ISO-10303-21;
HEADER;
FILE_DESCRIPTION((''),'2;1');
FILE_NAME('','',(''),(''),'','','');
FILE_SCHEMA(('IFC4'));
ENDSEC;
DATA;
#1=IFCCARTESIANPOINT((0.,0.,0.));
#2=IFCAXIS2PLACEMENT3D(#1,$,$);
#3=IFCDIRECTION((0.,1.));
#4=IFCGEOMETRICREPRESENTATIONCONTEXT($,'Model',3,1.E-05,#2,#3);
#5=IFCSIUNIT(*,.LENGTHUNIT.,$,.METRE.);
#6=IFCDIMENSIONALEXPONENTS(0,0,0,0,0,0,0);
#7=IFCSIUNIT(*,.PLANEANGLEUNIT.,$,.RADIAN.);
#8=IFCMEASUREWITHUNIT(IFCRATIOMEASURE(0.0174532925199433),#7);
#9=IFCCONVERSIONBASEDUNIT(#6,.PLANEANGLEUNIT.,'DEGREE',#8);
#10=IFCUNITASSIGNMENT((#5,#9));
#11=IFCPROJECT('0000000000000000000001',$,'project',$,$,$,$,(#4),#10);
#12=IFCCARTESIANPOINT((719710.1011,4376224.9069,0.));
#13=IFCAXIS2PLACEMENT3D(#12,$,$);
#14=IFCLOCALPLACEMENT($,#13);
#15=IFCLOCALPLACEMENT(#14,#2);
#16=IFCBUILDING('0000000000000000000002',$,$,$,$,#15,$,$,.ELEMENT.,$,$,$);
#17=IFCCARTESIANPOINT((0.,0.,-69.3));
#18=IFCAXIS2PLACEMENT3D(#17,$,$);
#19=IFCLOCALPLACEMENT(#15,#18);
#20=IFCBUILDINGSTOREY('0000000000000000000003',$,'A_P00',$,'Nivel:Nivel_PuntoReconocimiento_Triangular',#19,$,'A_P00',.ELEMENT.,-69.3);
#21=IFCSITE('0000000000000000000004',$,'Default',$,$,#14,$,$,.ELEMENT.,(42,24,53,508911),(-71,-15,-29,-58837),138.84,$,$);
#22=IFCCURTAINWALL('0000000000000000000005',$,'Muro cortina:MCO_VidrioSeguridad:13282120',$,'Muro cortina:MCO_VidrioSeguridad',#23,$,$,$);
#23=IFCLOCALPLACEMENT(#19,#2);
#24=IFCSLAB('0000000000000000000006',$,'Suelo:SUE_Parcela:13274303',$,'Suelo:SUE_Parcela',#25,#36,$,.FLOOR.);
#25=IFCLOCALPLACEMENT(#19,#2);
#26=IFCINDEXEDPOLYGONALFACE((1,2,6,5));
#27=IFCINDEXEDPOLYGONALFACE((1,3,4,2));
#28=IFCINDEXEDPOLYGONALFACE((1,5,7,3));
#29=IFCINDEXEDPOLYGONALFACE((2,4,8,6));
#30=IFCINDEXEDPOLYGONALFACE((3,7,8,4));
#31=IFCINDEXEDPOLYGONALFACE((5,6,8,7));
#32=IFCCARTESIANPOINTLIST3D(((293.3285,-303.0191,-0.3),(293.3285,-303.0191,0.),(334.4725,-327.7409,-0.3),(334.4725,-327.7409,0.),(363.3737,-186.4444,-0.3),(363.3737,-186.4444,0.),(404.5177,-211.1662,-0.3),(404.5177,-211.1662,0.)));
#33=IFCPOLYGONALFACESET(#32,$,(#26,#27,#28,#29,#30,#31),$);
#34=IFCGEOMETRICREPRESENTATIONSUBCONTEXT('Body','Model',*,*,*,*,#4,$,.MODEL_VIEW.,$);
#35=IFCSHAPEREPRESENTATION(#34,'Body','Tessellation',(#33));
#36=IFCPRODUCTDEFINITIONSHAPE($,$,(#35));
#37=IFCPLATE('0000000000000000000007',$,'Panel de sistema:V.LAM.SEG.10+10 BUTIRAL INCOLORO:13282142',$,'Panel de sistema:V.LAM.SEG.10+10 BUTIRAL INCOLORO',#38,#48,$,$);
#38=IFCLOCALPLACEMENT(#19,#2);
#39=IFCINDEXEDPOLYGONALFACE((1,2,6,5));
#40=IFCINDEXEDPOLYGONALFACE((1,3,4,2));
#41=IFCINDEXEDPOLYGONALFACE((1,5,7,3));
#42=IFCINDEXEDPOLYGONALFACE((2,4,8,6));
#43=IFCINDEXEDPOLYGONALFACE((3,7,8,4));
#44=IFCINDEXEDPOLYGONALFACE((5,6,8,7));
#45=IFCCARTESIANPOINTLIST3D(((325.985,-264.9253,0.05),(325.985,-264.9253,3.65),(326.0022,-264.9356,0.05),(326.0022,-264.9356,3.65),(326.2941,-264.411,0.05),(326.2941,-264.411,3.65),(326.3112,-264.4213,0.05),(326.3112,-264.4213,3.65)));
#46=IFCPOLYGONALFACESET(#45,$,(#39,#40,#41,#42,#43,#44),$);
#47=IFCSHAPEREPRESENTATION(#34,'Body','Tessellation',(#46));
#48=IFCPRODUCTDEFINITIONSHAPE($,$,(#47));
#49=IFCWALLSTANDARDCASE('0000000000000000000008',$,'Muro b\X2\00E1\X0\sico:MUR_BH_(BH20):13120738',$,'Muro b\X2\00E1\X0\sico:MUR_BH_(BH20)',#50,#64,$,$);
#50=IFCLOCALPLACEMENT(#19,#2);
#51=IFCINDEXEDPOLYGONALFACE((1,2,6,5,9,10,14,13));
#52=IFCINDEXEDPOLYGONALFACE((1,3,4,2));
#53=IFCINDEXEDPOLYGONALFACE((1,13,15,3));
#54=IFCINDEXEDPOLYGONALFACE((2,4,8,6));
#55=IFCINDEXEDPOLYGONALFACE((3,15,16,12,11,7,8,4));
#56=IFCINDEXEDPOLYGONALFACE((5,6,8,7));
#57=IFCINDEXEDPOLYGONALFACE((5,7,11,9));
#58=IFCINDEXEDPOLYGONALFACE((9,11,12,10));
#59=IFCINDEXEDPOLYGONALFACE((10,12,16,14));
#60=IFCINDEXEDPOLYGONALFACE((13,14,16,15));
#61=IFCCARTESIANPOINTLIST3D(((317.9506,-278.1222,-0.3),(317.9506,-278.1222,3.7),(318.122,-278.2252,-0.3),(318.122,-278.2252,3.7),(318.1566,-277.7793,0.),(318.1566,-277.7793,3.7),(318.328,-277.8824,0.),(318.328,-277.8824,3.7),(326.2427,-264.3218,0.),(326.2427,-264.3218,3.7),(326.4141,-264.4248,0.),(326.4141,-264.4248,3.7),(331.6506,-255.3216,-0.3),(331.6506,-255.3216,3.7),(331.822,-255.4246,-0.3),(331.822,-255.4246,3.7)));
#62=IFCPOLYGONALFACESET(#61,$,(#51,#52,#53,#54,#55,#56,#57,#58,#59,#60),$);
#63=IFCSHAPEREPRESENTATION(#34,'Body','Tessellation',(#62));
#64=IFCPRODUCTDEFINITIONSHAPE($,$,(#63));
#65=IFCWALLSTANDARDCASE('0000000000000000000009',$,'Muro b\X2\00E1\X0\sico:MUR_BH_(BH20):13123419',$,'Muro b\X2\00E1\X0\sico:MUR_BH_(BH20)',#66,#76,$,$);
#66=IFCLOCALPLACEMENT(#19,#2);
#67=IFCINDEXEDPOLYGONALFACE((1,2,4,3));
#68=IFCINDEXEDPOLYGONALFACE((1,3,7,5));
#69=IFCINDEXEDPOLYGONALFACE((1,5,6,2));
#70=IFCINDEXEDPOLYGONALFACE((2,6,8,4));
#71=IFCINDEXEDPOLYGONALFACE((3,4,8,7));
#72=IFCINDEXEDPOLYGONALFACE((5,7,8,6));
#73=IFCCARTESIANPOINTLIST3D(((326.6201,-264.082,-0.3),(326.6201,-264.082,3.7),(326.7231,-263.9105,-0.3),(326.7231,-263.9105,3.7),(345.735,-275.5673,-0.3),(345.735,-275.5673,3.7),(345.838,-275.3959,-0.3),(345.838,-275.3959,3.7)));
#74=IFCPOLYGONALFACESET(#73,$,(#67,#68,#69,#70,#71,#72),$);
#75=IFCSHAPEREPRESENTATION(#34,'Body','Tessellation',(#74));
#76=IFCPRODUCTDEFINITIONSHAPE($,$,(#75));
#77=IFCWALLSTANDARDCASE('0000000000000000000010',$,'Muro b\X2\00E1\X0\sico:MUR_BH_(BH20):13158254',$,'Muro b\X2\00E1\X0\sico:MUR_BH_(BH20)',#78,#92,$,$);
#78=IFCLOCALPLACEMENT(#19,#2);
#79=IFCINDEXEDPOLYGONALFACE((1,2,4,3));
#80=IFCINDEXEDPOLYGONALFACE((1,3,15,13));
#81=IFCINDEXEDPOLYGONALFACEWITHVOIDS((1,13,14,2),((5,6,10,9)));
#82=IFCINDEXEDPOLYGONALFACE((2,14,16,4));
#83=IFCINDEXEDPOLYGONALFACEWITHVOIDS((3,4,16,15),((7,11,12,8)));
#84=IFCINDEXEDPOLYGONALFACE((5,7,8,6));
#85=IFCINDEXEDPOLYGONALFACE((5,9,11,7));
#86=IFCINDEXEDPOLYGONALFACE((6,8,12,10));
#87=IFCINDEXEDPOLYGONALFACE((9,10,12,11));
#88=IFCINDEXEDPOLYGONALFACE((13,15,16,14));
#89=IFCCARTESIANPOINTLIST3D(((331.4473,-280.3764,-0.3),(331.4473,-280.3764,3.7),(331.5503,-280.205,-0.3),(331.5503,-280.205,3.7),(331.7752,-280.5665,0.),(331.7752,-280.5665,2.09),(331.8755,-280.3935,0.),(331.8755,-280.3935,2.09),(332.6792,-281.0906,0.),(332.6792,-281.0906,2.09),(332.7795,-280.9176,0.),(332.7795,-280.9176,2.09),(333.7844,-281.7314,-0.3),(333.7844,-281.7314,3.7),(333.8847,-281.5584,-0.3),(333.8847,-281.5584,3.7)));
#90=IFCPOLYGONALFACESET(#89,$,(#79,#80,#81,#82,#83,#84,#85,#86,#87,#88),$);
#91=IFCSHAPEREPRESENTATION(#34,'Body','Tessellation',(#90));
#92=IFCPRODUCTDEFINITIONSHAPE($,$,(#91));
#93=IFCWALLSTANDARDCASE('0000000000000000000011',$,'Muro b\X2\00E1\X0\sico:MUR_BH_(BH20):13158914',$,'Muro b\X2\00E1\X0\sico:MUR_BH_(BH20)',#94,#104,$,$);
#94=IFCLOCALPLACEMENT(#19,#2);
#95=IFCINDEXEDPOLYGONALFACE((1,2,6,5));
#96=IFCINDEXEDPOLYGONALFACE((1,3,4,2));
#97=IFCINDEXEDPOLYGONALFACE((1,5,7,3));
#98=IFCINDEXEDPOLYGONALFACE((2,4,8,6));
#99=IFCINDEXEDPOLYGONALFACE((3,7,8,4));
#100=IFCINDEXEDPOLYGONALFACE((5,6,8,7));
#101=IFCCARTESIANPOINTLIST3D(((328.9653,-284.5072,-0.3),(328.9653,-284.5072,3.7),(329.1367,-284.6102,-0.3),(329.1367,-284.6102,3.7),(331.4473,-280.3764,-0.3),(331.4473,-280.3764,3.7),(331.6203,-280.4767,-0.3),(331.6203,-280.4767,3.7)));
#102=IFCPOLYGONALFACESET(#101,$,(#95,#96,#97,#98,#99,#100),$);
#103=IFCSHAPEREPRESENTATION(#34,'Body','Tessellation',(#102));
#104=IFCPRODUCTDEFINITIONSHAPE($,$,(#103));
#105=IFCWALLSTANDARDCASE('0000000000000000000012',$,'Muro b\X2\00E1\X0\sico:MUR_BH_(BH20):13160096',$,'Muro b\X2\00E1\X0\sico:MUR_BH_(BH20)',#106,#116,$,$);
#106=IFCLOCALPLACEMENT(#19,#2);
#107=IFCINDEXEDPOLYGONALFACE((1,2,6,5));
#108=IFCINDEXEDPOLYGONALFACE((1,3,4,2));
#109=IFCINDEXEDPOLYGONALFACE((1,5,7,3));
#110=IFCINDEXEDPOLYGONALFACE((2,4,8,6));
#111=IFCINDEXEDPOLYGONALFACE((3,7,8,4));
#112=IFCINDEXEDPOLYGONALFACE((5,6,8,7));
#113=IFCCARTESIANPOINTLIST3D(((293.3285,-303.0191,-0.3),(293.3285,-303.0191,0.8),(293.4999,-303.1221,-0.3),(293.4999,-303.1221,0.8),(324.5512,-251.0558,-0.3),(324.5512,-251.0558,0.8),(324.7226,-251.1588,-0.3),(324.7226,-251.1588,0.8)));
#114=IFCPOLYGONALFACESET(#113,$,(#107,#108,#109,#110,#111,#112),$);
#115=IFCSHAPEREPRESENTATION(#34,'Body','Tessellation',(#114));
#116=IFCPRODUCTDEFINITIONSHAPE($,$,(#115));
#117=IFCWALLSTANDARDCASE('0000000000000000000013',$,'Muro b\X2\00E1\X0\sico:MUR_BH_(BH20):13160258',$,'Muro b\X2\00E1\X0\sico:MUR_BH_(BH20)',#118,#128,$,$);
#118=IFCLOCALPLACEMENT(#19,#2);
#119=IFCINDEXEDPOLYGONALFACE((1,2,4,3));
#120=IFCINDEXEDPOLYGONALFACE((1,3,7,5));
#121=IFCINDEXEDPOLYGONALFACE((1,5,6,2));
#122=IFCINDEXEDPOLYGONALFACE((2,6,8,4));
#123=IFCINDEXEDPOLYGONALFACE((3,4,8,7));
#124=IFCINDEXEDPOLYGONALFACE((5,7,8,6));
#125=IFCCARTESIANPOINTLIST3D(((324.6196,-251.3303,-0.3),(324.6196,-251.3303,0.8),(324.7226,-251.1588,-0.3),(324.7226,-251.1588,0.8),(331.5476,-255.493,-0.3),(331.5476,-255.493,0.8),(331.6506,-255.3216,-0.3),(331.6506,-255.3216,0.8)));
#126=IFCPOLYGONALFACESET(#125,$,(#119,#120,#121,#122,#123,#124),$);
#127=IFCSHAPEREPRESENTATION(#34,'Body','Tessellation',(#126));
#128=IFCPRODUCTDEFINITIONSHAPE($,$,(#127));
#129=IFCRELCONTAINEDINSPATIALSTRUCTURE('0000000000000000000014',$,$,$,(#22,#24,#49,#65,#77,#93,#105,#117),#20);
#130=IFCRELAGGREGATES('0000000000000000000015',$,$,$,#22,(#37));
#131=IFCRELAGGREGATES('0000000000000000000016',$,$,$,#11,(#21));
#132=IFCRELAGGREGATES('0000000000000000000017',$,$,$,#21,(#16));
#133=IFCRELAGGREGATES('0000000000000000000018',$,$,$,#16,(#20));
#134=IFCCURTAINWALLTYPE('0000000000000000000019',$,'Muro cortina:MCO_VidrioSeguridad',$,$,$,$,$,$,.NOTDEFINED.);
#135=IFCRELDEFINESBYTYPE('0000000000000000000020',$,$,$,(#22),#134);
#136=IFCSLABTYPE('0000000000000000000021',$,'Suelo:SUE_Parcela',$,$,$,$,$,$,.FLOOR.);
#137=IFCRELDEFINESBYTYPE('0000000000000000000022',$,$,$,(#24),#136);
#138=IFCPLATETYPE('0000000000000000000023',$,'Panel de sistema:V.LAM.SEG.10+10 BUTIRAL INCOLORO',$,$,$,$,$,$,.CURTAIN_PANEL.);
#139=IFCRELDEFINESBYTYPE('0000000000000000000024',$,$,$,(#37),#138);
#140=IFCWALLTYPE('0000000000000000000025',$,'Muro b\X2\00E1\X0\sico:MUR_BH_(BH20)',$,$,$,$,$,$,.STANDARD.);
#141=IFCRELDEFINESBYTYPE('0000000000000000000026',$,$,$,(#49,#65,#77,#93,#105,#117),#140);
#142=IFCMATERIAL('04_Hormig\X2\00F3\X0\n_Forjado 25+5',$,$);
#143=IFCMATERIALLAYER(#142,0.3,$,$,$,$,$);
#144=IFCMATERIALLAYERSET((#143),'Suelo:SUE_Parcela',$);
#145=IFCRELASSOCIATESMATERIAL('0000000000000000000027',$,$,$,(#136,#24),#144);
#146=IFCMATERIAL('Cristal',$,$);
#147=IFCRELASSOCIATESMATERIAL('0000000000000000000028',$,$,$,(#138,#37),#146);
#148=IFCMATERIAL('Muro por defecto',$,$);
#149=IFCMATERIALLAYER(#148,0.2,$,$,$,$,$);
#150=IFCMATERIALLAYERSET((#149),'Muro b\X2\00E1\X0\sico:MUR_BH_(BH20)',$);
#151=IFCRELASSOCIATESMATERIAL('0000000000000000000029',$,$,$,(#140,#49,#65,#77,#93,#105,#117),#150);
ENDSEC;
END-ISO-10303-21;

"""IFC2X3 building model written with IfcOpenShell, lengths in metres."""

from ifc_helpers import new_model, entity, si_unit, converted_unit, direction, frame, frame_2d, origin, origin_2d_with_axis, place, context, subcontext, project, spatial, polyline, rectangle, outline, extrude, source, transform, mapped, material, layer, layer_set, layer_usage, type_object, type_shapes, element, aggregate, save


model = new_model("IFC2X3")

# Units and contexts
model_context = context("Model", 3, precision=1e-05, world=origin(), true_north=direction((0.0, 1.0)))
body_context = subcontext(model_context, "Body", "Model", "MODEL_VIEW")
ifc_project = project(units=[si_unit("LENGTHUNIT", "METRE"), converted_unit("PLANEANGLEUNIT", "DEGREE", entity("IfcRatioMeasure", 0.0174532925199433), si_unit("PLANEANGLEUNIT", "RADIAN"), dimensions=[0, 0, 0, 0, 0, 0, 0])], contexts=[model_context])

# Site, building, storey
site_placement = place(None, frame((719710.1011, 4376224.9069, 0.0)))
site = spatial("IfcSite", under=ifc_project, at=site_placement, Name="Default", CompositionType="ELEMENT", RefLatitude=(42, 24, 53, 508911), RefLongitude=(-71, -15, -29, -58837), RefElevation=138.84)
building_placement = place(site_placement, origin())
building = spatial("IfcBuilding", under=site, at=building_placement, CompositionType="ELEMENT")
storey_placement = place(building_placement, frame((0.0, 0.0, -69.3)))
storey = spatial("IfcBuildingStorey", under=building, at=storey_placement, Name="A_P00", ObjectType="Nivel:Nivel_PuntoReconocimiento_Triangular", LongName="A_P00", CompositionType="ELEMENT", Elevation=-69.3)

# Curtain wall
curtain_wall_type = type_object("IfcCurtainWallType", Name="Muro cortina:MCO_VidrioSeguridad", PredefinedType="NOTDEFINED")
curtain_wall_placement = place(storey_placement, frame((0.0, 0.0, 69.3)))
curtain_wall = element("IfcCurtainWall", 1, at=curtain_wall_placement, inside=storey, type_object=curtain_wall_type, Name="Muro cortina:MCO_VidrioSeguridad:13282120", ObjectType="Muro cortina:MCO_VidrioSeguridad")
ifc_material_1 = material(Name="Cristal")

# Slab
ifc_material_2 = material(Name="04_Hormigón_Forjado 25+5")
ifc_layer_1 = layer(ifc_material_2, 0.3)
ifc_layer_set_1 = layer_set([ifc_layer_1], Name="Suelo:SUE_Parcela")
ifc_layer_usage_1 = layer_usage(ifc_layer_set_1, "AXIS3", "POSITIVE", 0.0)
slab_type_1 = type_object("IfcSlabType", Name="Suelo:SUE_Parcela", PredefinedType="FLOOR", material=ifc_layer_set_1)
slab_1_placement = place(storey_placement, origin())
element("IfcSlab", 2, at=slab_1_placement, inside=storey, type_object=slab_type_1, material=ifc_layer_usage_1, Name="Suelo:SUE_Parcela:13274303", ObjectType="Suelo:SUE_Parcela", PredefinedType="FLOOR", context=body_context, shape_type="SweptSolid", body=[
    extrude(rectangle(XDim=135.9999, YDim=48.0, at=frame_2d((0.0, 0.0), x_axis=(1.0, 0.0))), frame((348.9231, -257.0926, 0.0), z_axis=(0.0, 0.0, -1.0), x_axis=(-0.515038, -0.857167, 0.0)), (0.0, 0.0, 1.0), 0.3),
])

# Plate
plate_type_1 = type_object("IfcPlateType", Name="Panel de sistema:V.LAM.SEG.10+10 BUTIRAL INCOLORO", PredefinedType="CURTAIN_PANEL", material=ifc_material_1)
shared_shape_1 = source(origin(), body_context, "Body", "SweptSolid", [
    extrude(rectangle(XDim=0.02, YDim=0.6, at=origin_2d_with_axis()), frame((0.0, 0.0, 0.0), z_axis=(0.0, 0.0, 1.0), x_axis=(0.0, 1.0, 0.0)), (0.0, 0.0, 1.0), 3.6),
])
type_shapes(plate_type_1, [shared_shape_1])
plate_1_placement = place(curtain_wall_placement, frame((326.1481, -264.6733, -69.25), z_axis=(0.0, 0.0, 1.0), x_axis=(0.515038, 0.857167, 0.0)))
plate_1 = element("IfcPlate", 3, at=plate_1_placement, type_object=plate_type_1, material=ifc_material_1, Name="Panel de sistema:V.LAM.SEG.10+10 BUTIRAL INCOLORO:13282142", ObjectType="Panel de sistema:V.LAM.SEG.10+10 BUTIRAL INCOLORO", context=body_context, shape_type="MappedRepresentation", body=[
    mapped(shared_shape_1, transform((0.0, 0.0, 0.0), scale=1.0)),
])
aggregate(curtain_wall, [plate_1])

# Wall, opening
ifc_material_3 = material(Name="Muro por defecto")
ifc_layer_2 = layer(ifc_material_3, 0.2)
ifc_layer_set_2 = layer_set([ifc_layer_2], Name="Muro básico:MUR_BH_(BH20)")
ifc_layer_usage_2 = layer_usage(ifc_layer_set_2, "AXIS2", "NEGATIVE", 0.1)
wall_type = type_object("IfcWallType", Name="Muro básico:MUR_BH_(BH20)", PredefinedType="STANDARD", material=ifc_layer_set_2)
wall_1_placement = place(storey_placement, frame((318.0363, -278.1737, -0.3), z_axis=(0.0, 0.0, 1.0), x_axis=(0.515038, 0.857167, 0.0)))
wall_1 = element("IfcWallStandardCase", 4, at=wall_1_placement, inside=storey, type_object=wall_type, material=ifc_layer_usage_2, Name="Muro básico:MUR_BH_(BH20):13120738", ObjectType="Muro básico:MUR_BH_(BH20)", context=body_context, shape_type="SweptSolid", body=[
    extrude(rectangle(XDim=26.6, YDim=0.2, at=frame_2d((13.3, 0.0), x_axis=(-1.0, 0.0))), origin(), (0.0, 0.0, 1.0), 4.0),
])
opening_1_placement = place(wall_1_placement, origin())
element("IfcOpeningElement", 5, at=opening_1_placement, cuts=wall_1, ObjectType="Opening", context=body_context, shape_type="SweptSolid", body=[
    extrude(rectangle(XDim=3.7, YDim=15.7, at=frame_2d((0.0, 0.0), x_axis=(1.0, 0.0))), frame((8.25, -0.2524, 2.15), z_axis=(0.0, 1.0, 0.0), x_axis=(0.0, 0.0, 1.0)), (0.0, 0.0, 1.0), 0.5048),
])

# Wall
ifc_layer_usage_3 = layer_usage(ifc_layer_set_2, "AXIS2", "NEGATIVE", 0.1)
wall_2_placement = place(storey_placement, frame((326.6716, -263.9962, -0.3), z_axis=(0.0, 0.0, 1.0), x_axis=(0.857167, -0.515038, 0.0)))
element("IfcWallStandardCase", 6, at=wall_2_placement, inside=storey, type_object=wall_type, material=ifc_layer_usage_3, Name="Muro básico:MUR_BH_(BH20):13123419", ObjectType="Muro básico:MUR_BH_(BH20)", context=body_context, shape_type="SweptSolid", body=[
    extrude(rectangle(XDim=22.3, YDim=0.2, at=frame_2d((11.15, 0.0), x_axis=(-1.0, 0.0))), origin(), (0.0, 0.0, 1.0), 4.0),
])

# Wall, opening
ifc_layer_usage_4 = layer_usage(ifc_layer_set_2, "AXIS2", "NEGATIVE", 0.1)
wall_3_placement = place(storey_placement, frame((331.4974, -280.2899, -0.3), z_axis=(0.0, 0.0, 1.0), x_axis=(0.865126, -0.501555, 0.0)))
wall_3 = element("IfcWallStandardCase", 7, at=wall_3_placement, inside=storey, type_object=wall_type, material=ifc_layer_usage_4, Name="Muro básico:MUR_BH_(BH20):13158254", ObjectType="Muro básico:MUR_BH_(BH20)", context=body_context, shape_type="SweptSolid", body=[
    extrude(outline(polyline([(2.7015, -0.1), (2.7015, 0.1), (0.0031, 0.1), (0.0, -0.1), (0.2, -0.1), (2.7015, -0.1)])), origin(), (0.0, 0.0, 1.0), 4.0),
])
opening_2_placement = place(wall_3_placement, frame((-427.3678, 76.2218, 0.3), z_axis=(0.0, 0.0, 1.0), x_axis=(0.865126, 0.501555, 0.0)))
element("IfcOpeningElement", 8, at=opening_2_placement, cuts=wall_3, ObjectType="Opening", context=body_context, shape_type="SweptSolid", body=[
    extrude(rectangle(XDim=2.09, YDim=1.045, at=frame_2d((0.0, 0.0), x_axis=(0.0, 1.0))), frame((332.2272, -280.8286, 1.045), z_axis=(0.501555, 0.865126, 0.0), x_axis=(0.865126, -0.501555, 0.0)), (0.0, 0.0, 1.0), 0.2),
])

# Walls
ifc_layer_usage_5 = layer_usage(ifc_layer_set_2, "AXIS2", "NEGATIVE", 0.1)
wall_4_placement = place(storey_placement, frame((331.5346, -280.4252, -0.3), z_axis=(0.0, 0.0, 1.0), x_axis=(-0.515038, -0.857167, 0.0)))
element("IfcWallStandardCase", 9, at=wall_4_placement, inside=storey, type_object=wall_type, material=ifc_layer_usage_5, Name="Muro básico:MUR_BH_(BH20):13158914", ObjectType="Muro básico:MUR_BH_(BH20)", context=body_context, shape_type="SweptSolid", body=[
    extrude(outline(polyline([(4.8222, -0.1), (4.8222, 0.1), (0.0, 0.1), (0.0031, -0.1), (4.8222, -0.1)])), origin(), (0.0, 0.0, 1.0), 4.0),
])
ifc_layer_usage_6 = layer_usage(ifc_layer_set_2, "AXIS2", "NEGATIVE", 0.1)
wall_5_placement = place(storey_placement, frame((293.4142, -303.0706, -0.3), z_axis=(0.0, 0.0, 1.0), x_axis=(0.515038, 0.857167, 0.0)))
element("IfcWallStandardCase", 10, at=wall_5_placement, inside=storey, type_object=wall_type, material=ifc_layer_usage_6, Name="Muro básico:MUR_BH_(BH20):13160096", ObjectType="Muro básico:MUR_BH_(BH20)", context=body_context, shape_type="SweptSolid", body=[
    extrude(rectangle(XDim=60.6221, YDim=0.2, at=frame_2d((30.311, 0.0), x_axis=(-1.0, 0.0))), origin(), (0.0, 0.0, 1.0), 1.1),
])
ifc_layer_usage_7 = layer_usage(ifc_layer_set_2, "AXIS2", "NEGATIVE", 0.1)
wall_6_placement = place(storey_placement, frame((331.5991, -255.4073, -0.3), z_axis=(0.0, 0.0, 1.0), x_axis=(-0.857167, 0.515038, 0.0)))
element("IfcWallStandardCase", 11, at=wall_6_placement, inside=storey, type_object=wall_type, material=ifc_layer_usage_7, Name="Muro básico:MUR_BH_(BH20):13160258", ObjectType="Muro básico:MUR_BH_(BH20)", context=body_context, shape_type="SweptSolid", body=[
    extrude(rectangle(XDim=8.0824, YDim=0.2, at=frame_2d((4.0412, 0.0), x_axis=(-1.0, 0.0))), origin(), (0.0, 0.0, 1.0), 1.1),
])

save(model, "model.ifc")
